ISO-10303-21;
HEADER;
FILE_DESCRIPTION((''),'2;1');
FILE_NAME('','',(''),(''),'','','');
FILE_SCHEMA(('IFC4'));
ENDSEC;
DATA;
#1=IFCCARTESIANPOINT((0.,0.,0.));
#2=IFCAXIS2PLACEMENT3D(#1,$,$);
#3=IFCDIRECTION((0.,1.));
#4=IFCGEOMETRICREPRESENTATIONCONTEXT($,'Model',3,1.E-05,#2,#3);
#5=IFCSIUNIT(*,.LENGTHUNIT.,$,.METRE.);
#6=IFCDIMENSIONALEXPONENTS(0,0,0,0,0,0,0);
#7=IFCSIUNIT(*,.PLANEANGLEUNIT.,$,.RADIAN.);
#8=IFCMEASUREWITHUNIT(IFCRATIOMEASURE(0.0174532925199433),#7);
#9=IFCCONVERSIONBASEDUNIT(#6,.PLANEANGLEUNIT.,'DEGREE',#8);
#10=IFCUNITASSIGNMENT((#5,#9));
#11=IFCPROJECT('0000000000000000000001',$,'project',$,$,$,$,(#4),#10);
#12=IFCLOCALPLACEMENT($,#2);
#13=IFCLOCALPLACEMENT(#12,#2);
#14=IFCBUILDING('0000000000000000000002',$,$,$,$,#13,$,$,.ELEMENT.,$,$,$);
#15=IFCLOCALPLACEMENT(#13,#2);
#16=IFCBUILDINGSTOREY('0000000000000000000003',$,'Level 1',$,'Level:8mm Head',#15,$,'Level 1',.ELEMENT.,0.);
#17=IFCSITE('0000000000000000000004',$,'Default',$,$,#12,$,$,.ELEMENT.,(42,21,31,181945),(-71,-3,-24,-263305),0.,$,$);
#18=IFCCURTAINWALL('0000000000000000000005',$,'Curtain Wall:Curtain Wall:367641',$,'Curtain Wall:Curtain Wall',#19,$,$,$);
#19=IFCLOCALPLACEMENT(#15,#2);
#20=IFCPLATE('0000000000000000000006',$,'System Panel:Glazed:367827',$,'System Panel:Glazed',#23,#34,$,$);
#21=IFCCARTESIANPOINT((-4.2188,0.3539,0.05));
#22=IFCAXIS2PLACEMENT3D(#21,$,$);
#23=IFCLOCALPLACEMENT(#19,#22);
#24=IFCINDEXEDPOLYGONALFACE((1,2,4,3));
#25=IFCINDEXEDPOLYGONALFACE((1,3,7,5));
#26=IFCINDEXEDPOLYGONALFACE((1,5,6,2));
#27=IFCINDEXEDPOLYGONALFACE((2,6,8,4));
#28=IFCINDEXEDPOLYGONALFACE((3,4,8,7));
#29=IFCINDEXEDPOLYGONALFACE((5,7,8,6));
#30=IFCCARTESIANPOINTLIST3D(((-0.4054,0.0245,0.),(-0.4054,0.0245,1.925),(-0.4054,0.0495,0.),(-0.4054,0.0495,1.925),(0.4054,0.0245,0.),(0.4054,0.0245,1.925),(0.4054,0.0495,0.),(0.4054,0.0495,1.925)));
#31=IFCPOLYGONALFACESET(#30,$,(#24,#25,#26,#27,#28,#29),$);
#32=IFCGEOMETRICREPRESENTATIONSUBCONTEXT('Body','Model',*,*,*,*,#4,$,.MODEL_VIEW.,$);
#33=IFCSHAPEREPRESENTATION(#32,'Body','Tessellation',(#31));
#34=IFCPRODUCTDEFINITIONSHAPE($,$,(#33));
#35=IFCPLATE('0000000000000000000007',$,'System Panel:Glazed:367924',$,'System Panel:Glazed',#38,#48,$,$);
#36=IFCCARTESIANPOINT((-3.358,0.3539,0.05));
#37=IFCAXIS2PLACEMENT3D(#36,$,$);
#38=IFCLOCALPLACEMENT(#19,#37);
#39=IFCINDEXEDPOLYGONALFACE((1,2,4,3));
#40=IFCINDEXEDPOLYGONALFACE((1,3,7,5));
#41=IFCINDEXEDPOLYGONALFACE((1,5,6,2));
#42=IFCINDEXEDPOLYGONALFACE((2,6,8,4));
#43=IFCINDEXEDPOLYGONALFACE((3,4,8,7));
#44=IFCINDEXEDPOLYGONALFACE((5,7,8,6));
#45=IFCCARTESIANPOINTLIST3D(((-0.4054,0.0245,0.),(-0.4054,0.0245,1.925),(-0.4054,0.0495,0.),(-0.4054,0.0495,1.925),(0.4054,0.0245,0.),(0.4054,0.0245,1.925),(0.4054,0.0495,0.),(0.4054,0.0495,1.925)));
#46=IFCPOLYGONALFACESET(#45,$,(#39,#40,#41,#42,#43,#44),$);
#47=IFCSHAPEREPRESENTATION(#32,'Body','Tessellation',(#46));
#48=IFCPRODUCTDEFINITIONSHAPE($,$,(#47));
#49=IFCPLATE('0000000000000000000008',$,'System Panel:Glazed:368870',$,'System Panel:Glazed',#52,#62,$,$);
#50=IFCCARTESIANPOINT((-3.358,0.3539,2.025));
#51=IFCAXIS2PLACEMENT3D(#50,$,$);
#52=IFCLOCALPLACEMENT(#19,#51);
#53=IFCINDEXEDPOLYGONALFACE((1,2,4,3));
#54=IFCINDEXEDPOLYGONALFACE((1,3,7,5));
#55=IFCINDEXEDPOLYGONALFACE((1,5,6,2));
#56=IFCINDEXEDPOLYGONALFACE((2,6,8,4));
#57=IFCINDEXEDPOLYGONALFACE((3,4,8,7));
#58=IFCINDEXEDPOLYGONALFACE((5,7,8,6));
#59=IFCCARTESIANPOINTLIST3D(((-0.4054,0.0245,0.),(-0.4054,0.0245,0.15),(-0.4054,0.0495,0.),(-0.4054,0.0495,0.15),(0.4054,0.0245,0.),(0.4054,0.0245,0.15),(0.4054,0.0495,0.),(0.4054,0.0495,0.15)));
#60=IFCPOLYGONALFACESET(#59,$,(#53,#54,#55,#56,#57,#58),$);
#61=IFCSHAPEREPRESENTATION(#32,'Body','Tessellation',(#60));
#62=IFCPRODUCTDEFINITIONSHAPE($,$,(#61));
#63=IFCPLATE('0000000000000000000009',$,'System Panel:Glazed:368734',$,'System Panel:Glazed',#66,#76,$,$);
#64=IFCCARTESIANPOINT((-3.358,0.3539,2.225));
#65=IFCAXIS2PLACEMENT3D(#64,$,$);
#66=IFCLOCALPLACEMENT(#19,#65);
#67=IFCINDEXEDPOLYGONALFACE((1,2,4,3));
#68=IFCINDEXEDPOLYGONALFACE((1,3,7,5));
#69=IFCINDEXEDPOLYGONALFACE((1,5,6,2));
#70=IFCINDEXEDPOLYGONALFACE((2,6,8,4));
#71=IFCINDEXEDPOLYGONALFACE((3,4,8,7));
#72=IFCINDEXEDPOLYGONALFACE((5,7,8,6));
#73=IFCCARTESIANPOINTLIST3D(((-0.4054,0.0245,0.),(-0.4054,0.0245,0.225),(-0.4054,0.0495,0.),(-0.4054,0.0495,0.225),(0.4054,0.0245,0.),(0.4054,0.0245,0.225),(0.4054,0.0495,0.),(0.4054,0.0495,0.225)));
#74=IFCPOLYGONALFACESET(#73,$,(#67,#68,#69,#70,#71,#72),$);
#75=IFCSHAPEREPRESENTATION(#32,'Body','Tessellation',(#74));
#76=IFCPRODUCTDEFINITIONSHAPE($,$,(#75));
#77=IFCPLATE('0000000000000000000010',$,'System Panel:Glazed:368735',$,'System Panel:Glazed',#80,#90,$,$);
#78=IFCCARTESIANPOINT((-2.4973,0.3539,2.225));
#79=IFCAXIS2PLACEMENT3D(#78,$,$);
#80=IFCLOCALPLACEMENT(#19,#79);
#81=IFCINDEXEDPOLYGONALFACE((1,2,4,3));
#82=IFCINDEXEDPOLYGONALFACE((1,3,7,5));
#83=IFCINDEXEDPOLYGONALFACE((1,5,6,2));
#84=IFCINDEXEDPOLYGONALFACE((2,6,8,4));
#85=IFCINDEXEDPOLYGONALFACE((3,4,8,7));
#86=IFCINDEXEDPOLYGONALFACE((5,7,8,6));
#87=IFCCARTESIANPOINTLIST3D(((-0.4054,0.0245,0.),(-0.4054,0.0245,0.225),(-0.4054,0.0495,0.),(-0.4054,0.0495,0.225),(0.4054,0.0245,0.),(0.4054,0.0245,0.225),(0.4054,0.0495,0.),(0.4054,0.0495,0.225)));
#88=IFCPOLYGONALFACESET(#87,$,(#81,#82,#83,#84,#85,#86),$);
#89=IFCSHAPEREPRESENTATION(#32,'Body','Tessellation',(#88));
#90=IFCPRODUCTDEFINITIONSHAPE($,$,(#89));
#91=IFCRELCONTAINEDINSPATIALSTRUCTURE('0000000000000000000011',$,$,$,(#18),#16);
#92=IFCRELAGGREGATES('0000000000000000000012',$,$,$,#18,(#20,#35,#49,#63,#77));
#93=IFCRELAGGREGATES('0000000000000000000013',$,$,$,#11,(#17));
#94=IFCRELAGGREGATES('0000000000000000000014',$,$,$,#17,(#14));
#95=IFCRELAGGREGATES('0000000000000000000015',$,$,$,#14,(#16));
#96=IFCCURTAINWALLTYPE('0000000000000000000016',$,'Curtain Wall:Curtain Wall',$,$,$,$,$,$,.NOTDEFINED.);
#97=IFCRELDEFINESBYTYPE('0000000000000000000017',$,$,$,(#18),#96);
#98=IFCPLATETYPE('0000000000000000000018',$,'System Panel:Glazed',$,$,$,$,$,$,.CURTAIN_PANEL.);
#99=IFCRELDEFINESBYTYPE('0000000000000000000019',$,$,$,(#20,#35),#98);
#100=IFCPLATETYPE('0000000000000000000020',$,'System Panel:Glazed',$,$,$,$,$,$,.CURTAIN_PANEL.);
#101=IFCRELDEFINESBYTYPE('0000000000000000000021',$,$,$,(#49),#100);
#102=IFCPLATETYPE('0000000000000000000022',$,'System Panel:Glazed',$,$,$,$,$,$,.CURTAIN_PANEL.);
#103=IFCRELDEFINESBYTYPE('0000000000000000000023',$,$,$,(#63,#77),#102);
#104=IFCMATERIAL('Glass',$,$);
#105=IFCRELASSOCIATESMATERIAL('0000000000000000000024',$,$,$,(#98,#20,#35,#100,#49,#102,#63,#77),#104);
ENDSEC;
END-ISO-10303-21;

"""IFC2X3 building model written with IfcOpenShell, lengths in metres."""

from ifc_helpers import new_model, entity, si_unit, converted_unit, direction, frame, origin, origin_2d_with_axis, place, context, subcontext, project, spatial, rectangle, extrude, source, transform, mapped, material, type_object, type_shapes, element, aggregate, save


model = new_model("IFC2X3")

# Units and contexts
model_context = context("Model", 3, precision=1e-05, world=origin(), true_north=direction((0.0, 1.0)))
body_context = subcontext(model_context, "Body", "Model", "MODEL_VIEW")
ifc_project = project(units=[si_unit("LENGTHUNIT", "METRE"), converted_unit("PLANEANGLEUNIT", "DEGREE", entity("IfcRatioMeasure", 0.0174532925199433), si_unit("PLANEANGLEUNIT", "RADIAN"), dimensions=[0, 0, 0, 0, 0, 0, 0])], contexts=[model_context])

# Site, building, storey
site_placement = place(None, origin())
site = spatial("IfcSite", under=ifc_project, at=site_placement, Name="Default", CompositionType="ELEMENT", RefLatitude=(42, 21, 31, 181945), RefLongitude=(-71, -3, -24, -263305), RefElevation=0.0)
building_placement = place(site_placement, origin())
building = spatial("IfcBuilding", under=site, at=building_placement, CompositionType="ELEMENT")
storey_placement = place(building_placement, origin())
storey = spatial("IfcBuildingStorey", under=building, at=storey_placement, Name="Level 1", ObjectType="Level:8mm Head", LongName="Level 1", CompositionType="ELEMENT", Elevation=0.0)

# Curtain wall, plates
curtain_wall_type = type_object("IfcCurtainWallType", Name="Curtain Wall:Curtain Wall", PredefinedType="NOTDEFINED")
curtain_wall_placement = place(storey_placement, origin())
curtain_wall = element("IfcCurtainWall", 1, at=curtain_wall_placement, inside=storey, type_object=curtain_wall_type, Name="Curtain Wall:Curtain Wall:367641", ObjectType="Curtain Wall:Curtain Wall")
ifc_material_1 = material(Name="Glass")
plate_type_1 = type_object("IfcPlateType", Name="System Panel:Glazed", PredefinedType="CURTAIN_PANEL", material=ifc_material_1)
shared_shape_1 = source(origin(), body_context, "Body", "SweptSolid", [
    extrude(rectangle(XDim=0.025, YDim=0.8107, at=origin_2d_with_axis()), frame((0.0, 0.037, 0.0), z_axis=(0.0, 0.0, 1.0), x_axis=(0.0, 1.0, 0.0)), (0.0, 0.0, 1.0), 1.925),
])
type_shapes(plate_type_1, [shared_shape_1])
plate_1_placement = place(curtain_wall_placement, frame((-4.2188, 0.3539, 0.05)))
plate_1 = element("IfcPlate", 2, at=plate_1_placement, type_object=plate_type_1, material=ifc_material_1, Name="System Panel:Glazed:367827", ObjectType="System Panel:Glazed", context=body_context, shape_type="MappedRepresentation", body=[
    mapped(shared_shape_1, transform((0.0, 0.0, 0.0), scale=1.0)),
])
plate_2_placement = place(curtain_wall_placement, frame((-3.358, 0.3539, 0.05)))
plate_2 = element("IfcPlate", 3, at=plate_2_placement, type_object=plate_type_1, material=ifc_material_1, Name="System Panel:Glazed:367924", ObjectType="System Panel:Glazed", context=body_context, shape_type="MappedRepresentation", body=[
    mapped(shared_shape_1, transform((0.0, 0.0, 0.0), scale=1.0)),
])
plate_type_2 = type_object("IfcPlateType", Name="System Panel:Glazed", PredefinedType="CURTAIN_PANEL", material=ifc_material_1)
shared_shape_2 = source(origin(), body_context, "Body", "SweptSolid", [
    extrude(rectangle(XDim=0.025, YDim=0.8107, at=origin_2d_with_axis()), frame((0.0, 0.037, 0.0), z_axis=(0.0, 0.0, 1.0), x_axis=(0.0, 1.0, 0.0)), (0.0, 0.0, 1.0), 0.15),
])
type_shapes(plate_type_2, [shared_shape_2])
plate_3_placement = place(curtain_wall_placement, frame((-3.358, 0.3539, 2.025)))
plate_3 = element("IfcPlate", 4, at=plate_3_placement, type_object=plate_type_2, material=ifc_material_1, Name="System Panel:Glazed:368870", ObjectType="System Panel:Glazed", context=body_context, shape_type="MappedRepresentation", body=[
    mapped(shared_shape_2, transform((0.0, 0.0, 0.0), scale=1.0)),
])
plate_type_3 = type_object("IfcPlateType", Name="System Panel:Glazed", PredefinedType="CURTAIN_PANEL", material=ifc_material_1)
shared_shape_3 = source(origin(), body_context, "Body", "SweptSolid", [
    extrude(rectangle(XDim=0.025, YDim=0.8107, at=origin_2d_with_axis()), frame((0.0, 0.037, 0.0), z_axis=(0.0, 0.0, 1.0), x_axis=(0.0, 1.0, 0.0)), (0.0, 0.0, 1.0), 0.225),
])
type_shapes(plate_type_3, [shared_shape_3])
plate_4_placement = place(curtain_wall_placement, frame((-3.358, 0.3539, 2.225)))
plate_4 = element("IfcPlate", 5, at=plate_4_placement, type_object=plate_type_3, material=ifc_material_1, Name="System Panel:Glazed:368734", ObjectType="System Panel:Glazed", context=body_context, shape_type="MappedRepresentation", body=[
    mapped(shared_shape_3, transform((0.0, 0.0, 0.0), scale=1.0)),
])
plate_5_placement = place(curtain_wall_placement, frame((-2.4973, 0.3539, 2.225)))
plate_5 = element("IfcPlate", 6, at=plate_5_placement, type_object=plate_type_3, material=ifc_material_1, Name="System Panel:Glazed:368735", ObjectType="System Panel:Glazed", context=body_context, shape_type="MappedRepresentation", body=[
    mapped(shared_shape_3, transform((0.0, 0.0, 0.0), scale=1.0)),
])
aggregate(curtain_wall, [plate_1, plate_2, plate_3, plate_4, plate_5])

save(model, "model.ifc")
